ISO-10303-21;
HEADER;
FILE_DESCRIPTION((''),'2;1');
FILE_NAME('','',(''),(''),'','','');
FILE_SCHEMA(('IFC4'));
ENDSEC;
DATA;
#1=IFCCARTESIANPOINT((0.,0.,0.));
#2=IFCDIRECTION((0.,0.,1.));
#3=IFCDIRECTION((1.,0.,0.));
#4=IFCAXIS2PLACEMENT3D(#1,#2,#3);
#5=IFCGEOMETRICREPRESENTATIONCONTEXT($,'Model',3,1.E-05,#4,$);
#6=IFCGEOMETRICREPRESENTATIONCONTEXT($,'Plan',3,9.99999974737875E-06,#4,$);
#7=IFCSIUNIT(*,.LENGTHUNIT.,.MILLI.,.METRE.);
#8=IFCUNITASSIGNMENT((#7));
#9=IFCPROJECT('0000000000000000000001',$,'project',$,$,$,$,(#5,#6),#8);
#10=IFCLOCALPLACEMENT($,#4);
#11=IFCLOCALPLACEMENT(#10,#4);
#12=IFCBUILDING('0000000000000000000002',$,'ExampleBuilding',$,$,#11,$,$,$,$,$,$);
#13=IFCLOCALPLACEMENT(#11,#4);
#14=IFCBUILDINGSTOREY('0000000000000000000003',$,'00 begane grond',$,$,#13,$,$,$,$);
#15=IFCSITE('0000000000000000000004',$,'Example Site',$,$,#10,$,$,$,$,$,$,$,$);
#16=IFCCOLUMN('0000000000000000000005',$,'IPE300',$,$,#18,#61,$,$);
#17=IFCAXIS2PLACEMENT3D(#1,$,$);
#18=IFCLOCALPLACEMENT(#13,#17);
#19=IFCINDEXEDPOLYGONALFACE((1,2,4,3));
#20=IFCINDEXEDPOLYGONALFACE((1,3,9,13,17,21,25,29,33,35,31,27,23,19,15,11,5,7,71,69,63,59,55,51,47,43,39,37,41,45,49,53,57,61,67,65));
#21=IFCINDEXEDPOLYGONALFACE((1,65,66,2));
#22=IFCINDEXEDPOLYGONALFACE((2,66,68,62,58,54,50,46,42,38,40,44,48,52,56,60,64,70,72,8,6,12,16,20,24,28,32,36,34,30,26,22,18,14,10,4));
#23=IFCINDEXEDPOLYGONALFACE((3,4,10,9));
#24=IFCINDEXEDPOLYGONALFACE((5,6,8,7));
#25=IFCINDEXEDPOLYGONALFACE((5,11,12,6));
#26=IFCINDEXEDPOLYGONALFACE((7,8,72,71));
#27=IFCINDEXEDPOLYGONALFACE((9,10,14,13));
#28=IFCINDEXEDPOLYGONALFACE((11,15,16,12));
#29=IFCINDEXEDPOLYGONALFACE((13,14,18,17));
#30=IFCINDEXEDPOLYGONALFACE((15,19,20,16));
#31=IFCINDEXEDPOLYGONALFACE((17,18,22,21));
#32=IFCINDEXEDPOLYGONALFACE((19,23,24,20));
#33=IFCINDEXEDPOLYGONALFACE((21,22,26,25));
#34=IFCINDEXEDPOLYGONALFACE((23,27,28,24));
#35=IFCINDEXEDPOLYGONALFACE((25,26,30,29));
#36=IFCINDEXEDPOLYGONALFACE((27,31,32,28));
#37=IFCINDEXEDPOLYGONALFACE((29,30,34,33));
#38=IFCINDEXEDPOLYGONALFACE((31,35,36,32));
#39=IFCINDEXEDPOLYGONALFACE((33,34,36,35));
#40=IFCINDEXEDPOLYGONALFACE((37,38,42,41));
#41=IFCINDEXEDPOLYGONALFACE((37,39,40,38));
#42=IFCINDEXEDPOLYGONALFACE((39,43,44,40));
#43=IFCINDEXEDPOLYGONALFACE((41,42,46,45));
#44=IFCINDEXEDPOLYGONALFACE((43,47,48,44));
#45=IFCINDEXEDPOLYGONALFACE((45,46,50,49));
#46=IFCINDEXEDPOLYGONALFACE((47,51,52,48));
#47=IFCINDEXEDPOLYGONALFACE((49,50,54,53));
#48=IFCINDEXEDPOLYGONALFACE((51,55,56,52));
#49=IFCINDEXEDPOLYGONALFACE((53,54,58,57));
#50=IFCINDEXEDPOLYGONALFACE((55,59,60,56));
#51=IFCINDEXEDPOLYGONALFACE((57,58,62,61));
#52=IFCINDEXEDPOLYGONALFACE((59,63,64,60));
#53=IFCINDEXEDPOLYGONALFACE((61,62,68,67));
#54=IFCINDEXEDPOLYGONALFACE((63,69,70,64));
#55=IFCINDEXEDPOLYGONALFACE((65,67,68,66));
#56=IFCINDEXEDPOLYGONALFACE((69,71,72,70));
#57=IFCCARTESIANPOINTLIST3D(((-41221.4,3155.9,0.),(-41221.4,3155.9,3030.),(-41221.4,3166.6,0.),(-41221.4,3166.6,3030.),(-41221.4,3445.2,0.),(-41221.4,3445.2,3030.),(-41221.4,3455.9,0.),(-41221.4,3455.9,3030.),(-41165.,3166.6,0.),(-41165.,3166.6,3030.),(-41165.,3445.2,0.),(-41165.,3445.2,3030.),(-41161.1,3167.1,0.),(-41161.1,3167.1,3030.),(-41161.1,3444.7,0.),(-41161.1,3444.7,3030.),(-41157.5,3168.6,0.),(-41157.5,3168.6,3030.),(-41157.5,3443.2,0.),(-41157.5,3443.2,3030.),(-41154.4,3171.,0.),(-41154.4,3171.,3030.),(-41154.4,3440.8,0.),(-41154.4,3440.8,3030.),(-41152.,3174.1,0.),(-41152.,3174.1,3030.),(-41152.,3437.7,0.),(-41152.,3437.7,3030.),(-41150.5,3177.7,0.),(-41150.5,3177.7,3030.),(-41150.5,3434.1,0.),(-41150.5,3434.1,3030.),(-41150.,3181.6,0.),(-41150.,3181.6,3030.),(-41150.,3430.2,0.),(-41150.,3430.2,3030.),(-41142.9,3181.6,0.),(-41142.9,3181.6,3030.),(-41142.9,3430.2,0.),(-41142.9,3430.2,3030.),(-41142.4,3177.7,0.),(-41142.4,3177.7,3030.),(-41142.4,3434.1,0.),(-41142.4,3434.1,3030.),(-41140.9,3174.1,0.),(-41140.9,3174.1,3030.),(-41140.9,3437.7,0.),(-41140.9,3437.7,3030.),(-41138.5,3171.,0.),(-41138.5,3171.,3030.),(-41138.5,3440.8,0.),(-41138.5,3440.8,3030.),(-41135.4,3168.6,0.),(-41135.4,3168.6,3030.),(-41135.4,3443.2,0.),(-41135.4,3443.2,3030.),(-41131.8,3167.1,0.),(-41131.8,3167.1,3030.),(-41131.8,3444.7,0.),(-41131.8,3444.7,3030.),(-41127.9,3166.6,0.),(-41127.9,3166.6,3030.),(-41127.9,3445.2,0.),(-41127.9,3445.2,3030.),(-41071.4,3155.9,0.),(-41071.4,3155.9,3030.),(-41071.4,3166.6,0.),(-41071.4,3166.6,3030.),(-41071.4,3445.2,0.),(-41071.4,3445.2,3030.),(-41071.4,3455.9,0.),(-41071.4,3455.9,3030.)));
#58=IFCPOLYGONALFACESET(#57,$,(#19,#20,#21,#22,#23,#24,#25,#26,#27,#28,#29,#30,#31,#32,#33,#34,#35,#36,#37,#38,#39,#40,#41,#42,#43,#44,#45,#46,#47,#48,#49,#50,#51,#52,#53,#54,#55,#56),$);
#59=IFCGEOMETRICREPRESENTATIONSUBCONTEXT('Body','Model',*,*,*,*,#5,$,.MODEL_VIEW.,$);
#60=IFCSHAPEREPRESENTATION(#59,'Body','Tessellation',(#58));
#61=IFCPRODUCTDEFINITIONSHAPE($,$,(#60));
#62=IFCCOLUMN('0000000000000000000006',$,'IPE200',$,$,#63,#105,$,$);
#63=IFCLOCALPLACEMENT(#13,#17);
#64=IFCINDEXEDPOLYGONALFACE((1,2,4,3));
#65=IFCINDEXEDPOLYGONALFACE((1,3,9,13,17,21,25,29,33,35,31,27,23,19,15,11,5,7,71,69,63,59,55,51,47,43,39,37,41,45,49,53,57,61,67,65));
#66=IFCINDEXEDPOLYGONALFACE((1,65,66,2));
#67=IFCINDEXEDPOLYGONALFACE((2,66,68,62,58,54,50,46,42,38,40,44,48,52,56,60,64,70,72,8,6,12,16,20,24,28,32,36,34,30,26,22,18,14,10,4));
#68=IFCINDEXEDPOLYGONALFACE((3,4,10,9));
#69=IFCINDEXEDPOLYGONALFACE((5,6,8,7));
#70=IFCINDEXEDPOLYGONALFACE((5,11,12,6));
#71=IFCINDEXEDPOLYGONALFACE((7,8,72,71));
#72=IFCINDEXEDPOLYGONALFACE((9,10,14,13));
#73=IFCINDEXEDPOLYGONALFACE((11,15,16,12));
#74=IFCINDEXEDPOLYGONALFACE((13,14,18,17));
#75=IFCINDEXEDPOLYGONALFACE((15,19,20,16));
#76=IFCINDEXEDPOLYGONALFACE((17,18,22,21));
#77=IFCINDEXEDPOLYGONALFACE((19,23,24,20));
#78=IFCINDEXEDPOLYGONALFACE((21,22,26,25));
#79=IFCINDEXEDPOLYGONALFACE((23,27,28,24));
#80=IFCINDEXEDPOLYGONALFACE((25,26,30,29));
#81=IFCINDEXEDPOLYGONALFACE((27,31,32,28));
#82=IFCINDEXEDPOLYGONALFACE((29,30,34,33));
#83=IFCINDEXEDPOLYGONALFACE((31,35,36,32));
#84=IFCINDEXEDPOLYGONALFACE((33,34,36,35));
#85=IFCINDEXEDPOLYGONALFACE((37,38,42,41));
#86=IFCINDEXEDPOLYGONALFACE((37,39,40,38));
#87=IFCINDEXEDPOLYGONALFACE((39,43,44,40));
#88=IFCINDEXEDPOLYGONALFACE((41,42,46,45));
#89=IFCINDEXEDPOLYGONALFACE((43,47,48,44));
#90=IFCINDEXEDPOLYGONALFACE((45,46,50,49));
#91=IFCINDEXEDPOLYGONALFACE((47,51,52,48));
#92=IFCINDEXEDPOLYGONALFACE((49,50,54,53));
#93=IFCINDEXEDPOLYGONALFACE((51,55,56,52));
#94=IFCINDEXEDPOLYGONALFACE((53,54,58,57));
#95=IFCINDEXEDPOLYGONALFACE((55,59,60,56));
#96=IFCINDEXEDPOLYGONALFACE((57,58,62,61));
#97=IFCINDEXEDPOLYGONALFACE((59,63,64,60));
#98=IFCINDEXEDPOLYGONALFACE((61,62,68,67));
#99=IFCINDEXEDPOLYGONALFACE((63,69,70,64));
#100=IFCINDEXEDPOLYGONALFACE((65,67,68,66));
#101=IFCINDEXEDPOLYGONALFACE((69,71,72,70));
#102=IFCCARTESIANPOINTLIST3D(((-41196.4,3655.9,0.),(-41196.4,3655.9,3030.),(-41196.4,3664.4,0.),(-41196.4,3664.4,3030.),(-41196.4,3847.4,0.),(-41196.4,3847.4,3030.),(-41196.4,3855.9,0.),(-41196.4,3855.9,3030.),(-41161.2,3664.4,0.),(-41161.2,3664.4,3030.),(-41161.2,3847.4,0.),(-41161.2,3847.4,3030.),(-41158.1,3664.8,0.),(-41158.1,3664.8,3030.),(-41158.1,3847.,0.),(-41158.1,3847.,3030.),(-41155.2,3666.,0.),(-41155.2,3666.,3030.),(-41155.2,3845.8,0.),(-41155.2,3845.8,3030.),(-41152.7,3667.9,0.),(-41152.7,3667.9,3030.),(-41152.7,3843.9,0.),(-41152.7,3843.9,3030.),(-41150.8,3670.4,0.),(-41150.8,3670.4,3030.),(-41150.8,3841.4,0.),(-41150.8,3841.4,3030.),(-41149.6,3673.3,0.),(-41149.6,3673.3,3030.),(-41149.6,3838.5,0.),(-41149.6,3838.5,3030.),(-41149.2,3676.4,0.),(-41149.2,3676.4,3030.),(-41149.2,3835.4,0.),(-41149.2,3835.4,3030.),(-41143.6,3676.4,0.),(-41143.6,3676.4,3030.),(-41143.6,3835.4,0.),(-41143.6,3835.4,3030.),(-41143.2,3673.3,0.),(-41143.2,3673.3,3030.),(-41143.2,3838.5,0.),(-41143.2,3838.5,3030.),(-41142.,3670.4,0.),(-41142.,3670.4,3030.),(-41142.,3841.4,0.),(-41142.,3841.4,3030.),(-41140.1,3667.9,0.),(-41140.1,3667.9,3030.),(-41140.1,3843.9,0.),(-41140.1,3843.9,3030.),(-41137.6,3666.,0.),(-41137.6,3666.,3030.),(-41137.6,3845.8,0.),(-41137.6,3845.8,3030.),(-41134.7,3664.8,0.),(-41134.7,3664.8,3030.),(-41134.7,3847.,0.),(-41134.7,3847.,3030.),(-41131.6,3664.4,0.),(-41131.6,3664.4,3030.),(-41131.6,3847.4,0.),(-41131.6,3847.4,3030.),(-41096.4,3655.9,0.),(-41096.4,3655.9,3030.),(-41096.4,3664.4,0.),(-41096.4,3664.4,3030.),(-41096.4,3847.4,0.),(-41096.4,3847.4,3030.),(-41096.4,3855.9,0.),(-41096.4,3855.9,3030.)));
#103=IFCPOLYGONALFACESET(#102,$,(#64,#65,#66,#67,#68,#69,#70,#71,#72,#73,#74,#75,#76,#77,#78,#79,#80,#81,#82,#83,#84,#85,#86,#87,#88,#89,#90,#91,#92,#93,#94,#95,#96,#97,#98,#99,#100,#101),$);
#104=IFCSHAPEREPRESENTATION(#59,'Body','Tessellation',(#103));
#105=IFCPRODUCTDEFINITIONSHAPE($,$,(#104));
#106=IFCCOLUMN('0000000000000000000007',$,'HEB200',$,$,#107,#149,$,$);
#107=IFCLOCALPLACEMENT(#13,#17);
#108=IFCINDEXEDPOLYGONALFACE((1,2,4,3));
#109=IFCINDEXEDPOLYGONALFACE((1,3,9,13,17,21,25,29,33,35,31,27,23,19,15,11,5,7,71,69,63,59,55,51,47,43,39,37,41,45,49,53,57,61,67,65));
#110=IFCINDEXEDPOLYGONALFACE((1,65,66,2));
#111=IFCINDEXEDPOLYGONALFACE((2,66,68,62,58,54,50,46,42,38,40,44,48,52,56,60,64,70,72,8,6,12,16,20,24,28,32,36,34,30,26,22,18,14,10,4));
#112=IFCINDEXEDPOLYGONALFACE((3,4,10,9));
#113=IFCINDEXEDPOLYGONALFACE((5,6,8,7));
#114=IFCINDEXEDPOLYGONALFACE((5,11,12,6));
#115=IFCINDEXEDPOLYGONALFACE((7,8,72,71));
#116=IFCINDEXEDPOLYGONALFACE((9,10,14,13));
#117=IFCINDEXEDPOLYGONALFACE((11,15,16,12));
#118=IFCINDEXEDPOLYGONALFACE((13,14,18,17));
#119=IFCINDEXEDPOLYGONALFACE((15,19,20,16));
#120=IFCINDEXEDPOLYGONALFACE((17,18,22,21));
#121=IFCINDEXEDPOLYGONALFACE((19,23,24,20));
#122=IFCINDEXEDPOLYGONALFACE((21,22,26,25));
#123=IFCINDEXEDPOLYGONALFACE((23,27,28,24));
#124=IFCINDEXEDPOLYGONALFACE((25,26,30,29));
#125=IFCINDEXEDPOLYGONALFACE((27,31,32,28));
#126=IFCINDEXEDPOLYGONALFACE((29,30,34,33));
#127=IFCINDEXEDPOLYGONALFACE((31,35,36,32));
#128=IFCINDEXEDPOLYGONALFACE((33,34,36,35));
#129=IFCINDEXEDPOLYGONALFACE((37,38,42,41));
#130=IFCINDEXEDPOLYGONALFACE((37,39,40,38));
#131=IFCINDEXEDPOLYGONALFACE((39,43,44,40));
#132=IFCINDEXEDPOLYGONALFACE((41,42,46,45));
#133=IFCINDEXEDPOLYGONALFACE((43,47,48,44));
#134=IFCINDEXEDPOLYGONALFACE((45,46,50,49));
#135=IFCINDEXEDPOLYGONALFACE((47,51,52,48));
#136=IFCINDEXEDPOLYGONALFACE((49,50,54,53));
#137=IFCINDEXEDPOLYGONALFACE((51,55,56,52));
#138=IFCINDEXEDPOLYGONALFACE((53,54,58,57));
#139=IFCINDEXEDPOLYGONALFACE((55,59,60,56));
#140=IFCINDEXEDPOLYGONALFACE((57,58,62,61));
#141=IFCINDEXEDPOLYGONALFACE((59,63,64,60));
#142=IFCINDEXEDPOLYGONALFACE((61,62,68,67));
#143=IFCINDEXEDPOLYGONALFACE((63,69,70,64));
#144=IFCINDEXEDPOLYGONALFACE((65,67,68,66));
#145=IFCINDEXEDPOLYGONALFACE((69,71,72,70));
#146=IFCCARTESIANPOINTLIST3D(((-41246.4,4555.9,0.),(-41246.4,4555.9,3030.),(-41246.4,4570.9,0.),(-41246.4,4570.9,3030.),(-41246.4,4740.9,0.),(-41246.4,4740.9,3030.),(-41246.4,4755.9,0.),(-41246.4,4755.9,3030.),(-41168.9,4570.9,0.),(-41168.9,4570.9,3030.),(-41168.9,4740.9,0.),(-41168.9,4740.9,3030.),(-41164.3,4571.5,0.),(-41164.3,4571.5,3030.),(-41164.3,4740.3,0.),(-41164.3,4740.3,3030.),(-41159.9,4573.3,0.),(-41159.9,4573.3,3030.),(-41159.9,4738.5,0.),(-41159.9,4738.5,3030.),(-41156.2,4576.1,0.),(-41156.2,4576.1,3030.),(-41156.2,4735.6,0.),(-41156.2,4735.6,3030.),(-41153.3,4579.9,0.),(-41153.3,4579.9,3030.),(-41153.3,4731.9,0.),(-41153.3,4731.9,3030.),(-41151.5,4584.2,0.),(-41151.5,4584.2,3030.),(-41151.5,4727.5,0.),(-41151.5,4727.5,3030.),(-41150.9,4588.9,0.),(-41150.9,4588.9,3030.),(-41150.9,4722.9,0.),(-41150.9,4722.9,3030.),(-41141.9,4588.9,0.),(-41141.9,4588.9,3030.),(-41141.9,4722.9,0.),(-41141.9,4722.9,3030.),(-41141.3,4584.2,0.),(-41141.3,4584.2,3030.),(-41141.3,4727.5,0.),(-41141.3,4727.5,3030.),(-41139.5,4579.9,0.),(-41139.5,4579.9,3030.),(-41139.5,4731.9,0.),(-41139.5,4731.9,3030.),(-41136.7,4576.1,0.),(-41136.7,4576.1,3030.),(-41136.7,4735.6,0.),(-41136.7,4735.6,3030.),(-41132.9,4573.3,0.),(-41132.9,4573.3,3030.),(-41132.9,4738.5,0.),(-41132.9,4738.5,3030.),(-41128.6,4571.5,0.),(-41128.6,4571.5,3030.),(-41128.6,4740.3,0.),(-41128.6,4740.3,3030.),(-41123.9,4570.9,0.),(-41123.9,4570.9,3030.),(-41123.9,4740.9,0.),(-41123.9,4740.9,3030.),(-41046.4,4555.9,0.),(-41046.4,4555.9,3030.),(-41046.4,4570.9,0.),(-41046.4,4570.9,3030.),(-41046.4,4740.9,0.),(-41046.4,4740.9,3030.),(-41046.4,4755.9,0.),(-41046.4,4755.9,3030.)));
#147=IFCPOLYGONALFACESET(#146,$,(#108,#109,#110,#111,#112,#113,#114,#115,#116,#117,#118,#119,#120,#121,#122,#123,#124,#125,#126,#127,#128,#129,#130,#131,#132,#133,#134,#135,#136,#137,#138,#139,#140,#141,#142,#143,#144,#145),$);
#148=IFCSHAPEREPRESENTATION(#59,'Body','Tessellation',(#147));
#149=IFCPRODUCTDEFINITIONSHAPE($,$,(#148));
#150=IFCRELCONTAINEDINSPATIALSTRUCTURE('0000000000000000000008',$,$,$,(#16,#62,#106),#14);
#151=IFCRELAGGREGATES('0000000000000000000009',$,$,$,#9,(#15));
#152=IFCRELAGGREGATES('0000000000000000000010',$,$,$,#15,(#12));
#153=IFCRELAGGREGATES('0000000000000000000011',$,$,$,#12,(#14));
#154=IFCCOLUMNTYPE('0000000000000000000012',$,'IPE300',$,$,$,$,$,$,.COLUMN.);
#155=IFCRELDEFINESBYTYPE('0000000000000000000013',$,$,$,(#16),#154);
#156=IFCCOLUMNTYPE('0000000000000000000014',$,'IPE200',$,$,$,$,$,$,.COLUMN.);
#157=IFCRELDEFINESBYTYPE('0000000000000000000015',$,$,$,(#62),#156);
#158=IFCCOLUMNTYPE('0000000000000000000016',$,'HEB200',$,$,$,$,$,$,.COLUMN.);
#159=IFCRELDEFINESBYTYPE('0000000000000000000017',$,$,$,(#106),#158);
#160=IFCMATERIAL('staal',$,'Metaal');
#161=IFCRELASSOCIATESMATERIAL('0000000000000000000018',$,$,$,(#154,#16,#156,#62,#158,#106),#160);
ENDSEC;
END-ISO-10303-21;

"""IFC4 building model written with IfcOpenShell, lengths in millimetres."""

from ifc_helpers import new_model, si_unit, frame, origin_with_axes, place, context, subcontext, project, spatial, i_section, extrude, material, material_profile, profile_set, profile_usage, type_object, element, save


model = new_model("IFC4")

# Units and contexts
model_context = context("Model", 3, precision=1e-05, world=origin_with_axes())
plan_context = context("Plan", 3, precision=9.99999974737875e-06, world=origin_with_axes())
body_context = subcontext(model_context, "Body", "Model", "MODEL_VIEW")
ifc_project = project(units=[si_unit("LENGTHUNIT", "METRE", prefix="MILLI")], contexts=[model_context, plan_context])

# Site, building, storey
site_placement = place(None, frame((0.0, 0.0, 0.0), z_axis=(0.0, 0.0, 1.0), x_axis=(1.0, 0.0, 0.0)))
site = spatial("IfcSite", under=ifc_project, at=site_placement, Name="Example Site")
building_placement = place(site_placement, frame((0.0, 0.0, 0.0), z_axis=(0.0, 0.0, 1.0), x_axis=(1.0, 0.0, 0.0)))
building = spatial("IfcBuilding", under=site, at=building_placement, Name="ExampleBuilding")
storey_placement = place(building_placement, frame((0.0, 0.0, 0.0), z_axis=(0.0, 0.0, 1.0), x_axis=(1.0, 0.0, 0.0)))
storey = spatial("IfcBuildingStorey", under=building, at=storey_placement, Name="00 begane grond")

# Columns
ifc_material_1 = material(Name="staal", Category="Metaal")
ifc_material_profile_1 = material_profile(ifc_material_1, i_section(OverallWidth=150.0, OverallDepth=300.0, WebThickness=7.1, FlangeThickness=10.7, FilletRadius=15.0))
ifc_profile_set_1 = profile_set([ifc_material_profile_1], Name="staal")
ifc_profile_usage_1 = profile_usage(ifc_profile_set_1)
column_type_1 = type_object("IfcColumnType", Name="IPE300", PredefinedType="COLUMN", material=ifc_profile_set_1)
column_1_placement = place(storey_placement, frame((-41146.4, 3305.9, 0.0), z_axis=(0.0, 0.0, 1.0), x_axis=(1.0, 0.0, 0.0)))
element("IfcColumn", 1, at=column_1_placement, inside=storey, type_object=column_type_1, material=ifc_profile_usage_1, Name="IPE300", context=body_context, shape_type="SweptSolid", body=[
    extrude(i_section(OverallWidth=150.0, OverallDepth=300.0, WebThickness=7.1, FlangeThickness=10.7, FilletRadius=15.0), origin_with_axes(), (0.0, 0.0, 1.0), 3030.0),
])
ifc_material_profile_2 = material_profile(ifc_material_1, i_section(OverallWidth=100.0, OverallDepth=200.0, WebThickness=5.6, FlangeThickness=8.5, FilletRadius=12.0))
ifc_profile_set_2 = profile_set([ifc_material_profile_2], Name="staal")
ifc_profile_usage_2 = profile_usage(ifc_profile_set_2)
column_type_2 = type_object("IfcColumnType", Name="IPE200", PredefinedType="COLUMN", material=ifc_profile_set_2)
column_2_placement = place(storey_placement, frame((-41146.4, 3755.9, 0.0), z_axis=(0.0, 0.0, 1.0), x_axis=(1.0, 0.0, 0.0)))
element("IfcColumn", 2, at=column_2_placement, inside=storey, type_object=column_type_2, material=ifc_profile_usage_2, Name="IPE200", context=body_context, shape_type="SweptSolid", body=[
    extrude(i_section(OverallWidth=100.0, OverallDepth=200.0, WebThickness=5.6, FlangeThickness=8.5, FilletRadius=12.0), origin_with_axes(), (0.0, 0.0, 1.0), 3030.0),
])
ifc_material_profile_3 = material_profile(ifc_material_1, i_section(OverallWidth=200.0, OverallDepth=200.0, WebThickness=9.0, FlangeThickness=15.0, FilletRadius=18.0))
ifc_profile_set_3 = profile_set([ifc_material_profile_3], Name="staal")
ifc_profile_usage_3 = profile_usage(ifc_profile_set_3, cardinal=5)
column_type_3 = type_object("IfcColumnType", Name="HEB200", PredefinedType="COLUMN", material=ifc_profile_set_3)
column_3_placement = place(storey_placement, frame((-41146.4, 4655.9, 0.0), z_axis=(0.0, 0.0, 1.0), x_axis=(1.0, 0.0, 0.0)))
element("IfcColumn", 3, at=column_3_placement, inside=storey, type_object=column_type_3, material=ifc_profile_usage_3, Name="HEB200", context=body_context, shape_type="SweptSolid", body=[
    extrude(i_section(OverallWidth=200.0, OverallDepth=200.0, WebThickness=9.0, FlangeThickness=15.0, FilletRadius=18.0), origin_with_axes(), (0.0, 0.0, 1.0), 3030.0),
])

save(model, "model.ifc")
